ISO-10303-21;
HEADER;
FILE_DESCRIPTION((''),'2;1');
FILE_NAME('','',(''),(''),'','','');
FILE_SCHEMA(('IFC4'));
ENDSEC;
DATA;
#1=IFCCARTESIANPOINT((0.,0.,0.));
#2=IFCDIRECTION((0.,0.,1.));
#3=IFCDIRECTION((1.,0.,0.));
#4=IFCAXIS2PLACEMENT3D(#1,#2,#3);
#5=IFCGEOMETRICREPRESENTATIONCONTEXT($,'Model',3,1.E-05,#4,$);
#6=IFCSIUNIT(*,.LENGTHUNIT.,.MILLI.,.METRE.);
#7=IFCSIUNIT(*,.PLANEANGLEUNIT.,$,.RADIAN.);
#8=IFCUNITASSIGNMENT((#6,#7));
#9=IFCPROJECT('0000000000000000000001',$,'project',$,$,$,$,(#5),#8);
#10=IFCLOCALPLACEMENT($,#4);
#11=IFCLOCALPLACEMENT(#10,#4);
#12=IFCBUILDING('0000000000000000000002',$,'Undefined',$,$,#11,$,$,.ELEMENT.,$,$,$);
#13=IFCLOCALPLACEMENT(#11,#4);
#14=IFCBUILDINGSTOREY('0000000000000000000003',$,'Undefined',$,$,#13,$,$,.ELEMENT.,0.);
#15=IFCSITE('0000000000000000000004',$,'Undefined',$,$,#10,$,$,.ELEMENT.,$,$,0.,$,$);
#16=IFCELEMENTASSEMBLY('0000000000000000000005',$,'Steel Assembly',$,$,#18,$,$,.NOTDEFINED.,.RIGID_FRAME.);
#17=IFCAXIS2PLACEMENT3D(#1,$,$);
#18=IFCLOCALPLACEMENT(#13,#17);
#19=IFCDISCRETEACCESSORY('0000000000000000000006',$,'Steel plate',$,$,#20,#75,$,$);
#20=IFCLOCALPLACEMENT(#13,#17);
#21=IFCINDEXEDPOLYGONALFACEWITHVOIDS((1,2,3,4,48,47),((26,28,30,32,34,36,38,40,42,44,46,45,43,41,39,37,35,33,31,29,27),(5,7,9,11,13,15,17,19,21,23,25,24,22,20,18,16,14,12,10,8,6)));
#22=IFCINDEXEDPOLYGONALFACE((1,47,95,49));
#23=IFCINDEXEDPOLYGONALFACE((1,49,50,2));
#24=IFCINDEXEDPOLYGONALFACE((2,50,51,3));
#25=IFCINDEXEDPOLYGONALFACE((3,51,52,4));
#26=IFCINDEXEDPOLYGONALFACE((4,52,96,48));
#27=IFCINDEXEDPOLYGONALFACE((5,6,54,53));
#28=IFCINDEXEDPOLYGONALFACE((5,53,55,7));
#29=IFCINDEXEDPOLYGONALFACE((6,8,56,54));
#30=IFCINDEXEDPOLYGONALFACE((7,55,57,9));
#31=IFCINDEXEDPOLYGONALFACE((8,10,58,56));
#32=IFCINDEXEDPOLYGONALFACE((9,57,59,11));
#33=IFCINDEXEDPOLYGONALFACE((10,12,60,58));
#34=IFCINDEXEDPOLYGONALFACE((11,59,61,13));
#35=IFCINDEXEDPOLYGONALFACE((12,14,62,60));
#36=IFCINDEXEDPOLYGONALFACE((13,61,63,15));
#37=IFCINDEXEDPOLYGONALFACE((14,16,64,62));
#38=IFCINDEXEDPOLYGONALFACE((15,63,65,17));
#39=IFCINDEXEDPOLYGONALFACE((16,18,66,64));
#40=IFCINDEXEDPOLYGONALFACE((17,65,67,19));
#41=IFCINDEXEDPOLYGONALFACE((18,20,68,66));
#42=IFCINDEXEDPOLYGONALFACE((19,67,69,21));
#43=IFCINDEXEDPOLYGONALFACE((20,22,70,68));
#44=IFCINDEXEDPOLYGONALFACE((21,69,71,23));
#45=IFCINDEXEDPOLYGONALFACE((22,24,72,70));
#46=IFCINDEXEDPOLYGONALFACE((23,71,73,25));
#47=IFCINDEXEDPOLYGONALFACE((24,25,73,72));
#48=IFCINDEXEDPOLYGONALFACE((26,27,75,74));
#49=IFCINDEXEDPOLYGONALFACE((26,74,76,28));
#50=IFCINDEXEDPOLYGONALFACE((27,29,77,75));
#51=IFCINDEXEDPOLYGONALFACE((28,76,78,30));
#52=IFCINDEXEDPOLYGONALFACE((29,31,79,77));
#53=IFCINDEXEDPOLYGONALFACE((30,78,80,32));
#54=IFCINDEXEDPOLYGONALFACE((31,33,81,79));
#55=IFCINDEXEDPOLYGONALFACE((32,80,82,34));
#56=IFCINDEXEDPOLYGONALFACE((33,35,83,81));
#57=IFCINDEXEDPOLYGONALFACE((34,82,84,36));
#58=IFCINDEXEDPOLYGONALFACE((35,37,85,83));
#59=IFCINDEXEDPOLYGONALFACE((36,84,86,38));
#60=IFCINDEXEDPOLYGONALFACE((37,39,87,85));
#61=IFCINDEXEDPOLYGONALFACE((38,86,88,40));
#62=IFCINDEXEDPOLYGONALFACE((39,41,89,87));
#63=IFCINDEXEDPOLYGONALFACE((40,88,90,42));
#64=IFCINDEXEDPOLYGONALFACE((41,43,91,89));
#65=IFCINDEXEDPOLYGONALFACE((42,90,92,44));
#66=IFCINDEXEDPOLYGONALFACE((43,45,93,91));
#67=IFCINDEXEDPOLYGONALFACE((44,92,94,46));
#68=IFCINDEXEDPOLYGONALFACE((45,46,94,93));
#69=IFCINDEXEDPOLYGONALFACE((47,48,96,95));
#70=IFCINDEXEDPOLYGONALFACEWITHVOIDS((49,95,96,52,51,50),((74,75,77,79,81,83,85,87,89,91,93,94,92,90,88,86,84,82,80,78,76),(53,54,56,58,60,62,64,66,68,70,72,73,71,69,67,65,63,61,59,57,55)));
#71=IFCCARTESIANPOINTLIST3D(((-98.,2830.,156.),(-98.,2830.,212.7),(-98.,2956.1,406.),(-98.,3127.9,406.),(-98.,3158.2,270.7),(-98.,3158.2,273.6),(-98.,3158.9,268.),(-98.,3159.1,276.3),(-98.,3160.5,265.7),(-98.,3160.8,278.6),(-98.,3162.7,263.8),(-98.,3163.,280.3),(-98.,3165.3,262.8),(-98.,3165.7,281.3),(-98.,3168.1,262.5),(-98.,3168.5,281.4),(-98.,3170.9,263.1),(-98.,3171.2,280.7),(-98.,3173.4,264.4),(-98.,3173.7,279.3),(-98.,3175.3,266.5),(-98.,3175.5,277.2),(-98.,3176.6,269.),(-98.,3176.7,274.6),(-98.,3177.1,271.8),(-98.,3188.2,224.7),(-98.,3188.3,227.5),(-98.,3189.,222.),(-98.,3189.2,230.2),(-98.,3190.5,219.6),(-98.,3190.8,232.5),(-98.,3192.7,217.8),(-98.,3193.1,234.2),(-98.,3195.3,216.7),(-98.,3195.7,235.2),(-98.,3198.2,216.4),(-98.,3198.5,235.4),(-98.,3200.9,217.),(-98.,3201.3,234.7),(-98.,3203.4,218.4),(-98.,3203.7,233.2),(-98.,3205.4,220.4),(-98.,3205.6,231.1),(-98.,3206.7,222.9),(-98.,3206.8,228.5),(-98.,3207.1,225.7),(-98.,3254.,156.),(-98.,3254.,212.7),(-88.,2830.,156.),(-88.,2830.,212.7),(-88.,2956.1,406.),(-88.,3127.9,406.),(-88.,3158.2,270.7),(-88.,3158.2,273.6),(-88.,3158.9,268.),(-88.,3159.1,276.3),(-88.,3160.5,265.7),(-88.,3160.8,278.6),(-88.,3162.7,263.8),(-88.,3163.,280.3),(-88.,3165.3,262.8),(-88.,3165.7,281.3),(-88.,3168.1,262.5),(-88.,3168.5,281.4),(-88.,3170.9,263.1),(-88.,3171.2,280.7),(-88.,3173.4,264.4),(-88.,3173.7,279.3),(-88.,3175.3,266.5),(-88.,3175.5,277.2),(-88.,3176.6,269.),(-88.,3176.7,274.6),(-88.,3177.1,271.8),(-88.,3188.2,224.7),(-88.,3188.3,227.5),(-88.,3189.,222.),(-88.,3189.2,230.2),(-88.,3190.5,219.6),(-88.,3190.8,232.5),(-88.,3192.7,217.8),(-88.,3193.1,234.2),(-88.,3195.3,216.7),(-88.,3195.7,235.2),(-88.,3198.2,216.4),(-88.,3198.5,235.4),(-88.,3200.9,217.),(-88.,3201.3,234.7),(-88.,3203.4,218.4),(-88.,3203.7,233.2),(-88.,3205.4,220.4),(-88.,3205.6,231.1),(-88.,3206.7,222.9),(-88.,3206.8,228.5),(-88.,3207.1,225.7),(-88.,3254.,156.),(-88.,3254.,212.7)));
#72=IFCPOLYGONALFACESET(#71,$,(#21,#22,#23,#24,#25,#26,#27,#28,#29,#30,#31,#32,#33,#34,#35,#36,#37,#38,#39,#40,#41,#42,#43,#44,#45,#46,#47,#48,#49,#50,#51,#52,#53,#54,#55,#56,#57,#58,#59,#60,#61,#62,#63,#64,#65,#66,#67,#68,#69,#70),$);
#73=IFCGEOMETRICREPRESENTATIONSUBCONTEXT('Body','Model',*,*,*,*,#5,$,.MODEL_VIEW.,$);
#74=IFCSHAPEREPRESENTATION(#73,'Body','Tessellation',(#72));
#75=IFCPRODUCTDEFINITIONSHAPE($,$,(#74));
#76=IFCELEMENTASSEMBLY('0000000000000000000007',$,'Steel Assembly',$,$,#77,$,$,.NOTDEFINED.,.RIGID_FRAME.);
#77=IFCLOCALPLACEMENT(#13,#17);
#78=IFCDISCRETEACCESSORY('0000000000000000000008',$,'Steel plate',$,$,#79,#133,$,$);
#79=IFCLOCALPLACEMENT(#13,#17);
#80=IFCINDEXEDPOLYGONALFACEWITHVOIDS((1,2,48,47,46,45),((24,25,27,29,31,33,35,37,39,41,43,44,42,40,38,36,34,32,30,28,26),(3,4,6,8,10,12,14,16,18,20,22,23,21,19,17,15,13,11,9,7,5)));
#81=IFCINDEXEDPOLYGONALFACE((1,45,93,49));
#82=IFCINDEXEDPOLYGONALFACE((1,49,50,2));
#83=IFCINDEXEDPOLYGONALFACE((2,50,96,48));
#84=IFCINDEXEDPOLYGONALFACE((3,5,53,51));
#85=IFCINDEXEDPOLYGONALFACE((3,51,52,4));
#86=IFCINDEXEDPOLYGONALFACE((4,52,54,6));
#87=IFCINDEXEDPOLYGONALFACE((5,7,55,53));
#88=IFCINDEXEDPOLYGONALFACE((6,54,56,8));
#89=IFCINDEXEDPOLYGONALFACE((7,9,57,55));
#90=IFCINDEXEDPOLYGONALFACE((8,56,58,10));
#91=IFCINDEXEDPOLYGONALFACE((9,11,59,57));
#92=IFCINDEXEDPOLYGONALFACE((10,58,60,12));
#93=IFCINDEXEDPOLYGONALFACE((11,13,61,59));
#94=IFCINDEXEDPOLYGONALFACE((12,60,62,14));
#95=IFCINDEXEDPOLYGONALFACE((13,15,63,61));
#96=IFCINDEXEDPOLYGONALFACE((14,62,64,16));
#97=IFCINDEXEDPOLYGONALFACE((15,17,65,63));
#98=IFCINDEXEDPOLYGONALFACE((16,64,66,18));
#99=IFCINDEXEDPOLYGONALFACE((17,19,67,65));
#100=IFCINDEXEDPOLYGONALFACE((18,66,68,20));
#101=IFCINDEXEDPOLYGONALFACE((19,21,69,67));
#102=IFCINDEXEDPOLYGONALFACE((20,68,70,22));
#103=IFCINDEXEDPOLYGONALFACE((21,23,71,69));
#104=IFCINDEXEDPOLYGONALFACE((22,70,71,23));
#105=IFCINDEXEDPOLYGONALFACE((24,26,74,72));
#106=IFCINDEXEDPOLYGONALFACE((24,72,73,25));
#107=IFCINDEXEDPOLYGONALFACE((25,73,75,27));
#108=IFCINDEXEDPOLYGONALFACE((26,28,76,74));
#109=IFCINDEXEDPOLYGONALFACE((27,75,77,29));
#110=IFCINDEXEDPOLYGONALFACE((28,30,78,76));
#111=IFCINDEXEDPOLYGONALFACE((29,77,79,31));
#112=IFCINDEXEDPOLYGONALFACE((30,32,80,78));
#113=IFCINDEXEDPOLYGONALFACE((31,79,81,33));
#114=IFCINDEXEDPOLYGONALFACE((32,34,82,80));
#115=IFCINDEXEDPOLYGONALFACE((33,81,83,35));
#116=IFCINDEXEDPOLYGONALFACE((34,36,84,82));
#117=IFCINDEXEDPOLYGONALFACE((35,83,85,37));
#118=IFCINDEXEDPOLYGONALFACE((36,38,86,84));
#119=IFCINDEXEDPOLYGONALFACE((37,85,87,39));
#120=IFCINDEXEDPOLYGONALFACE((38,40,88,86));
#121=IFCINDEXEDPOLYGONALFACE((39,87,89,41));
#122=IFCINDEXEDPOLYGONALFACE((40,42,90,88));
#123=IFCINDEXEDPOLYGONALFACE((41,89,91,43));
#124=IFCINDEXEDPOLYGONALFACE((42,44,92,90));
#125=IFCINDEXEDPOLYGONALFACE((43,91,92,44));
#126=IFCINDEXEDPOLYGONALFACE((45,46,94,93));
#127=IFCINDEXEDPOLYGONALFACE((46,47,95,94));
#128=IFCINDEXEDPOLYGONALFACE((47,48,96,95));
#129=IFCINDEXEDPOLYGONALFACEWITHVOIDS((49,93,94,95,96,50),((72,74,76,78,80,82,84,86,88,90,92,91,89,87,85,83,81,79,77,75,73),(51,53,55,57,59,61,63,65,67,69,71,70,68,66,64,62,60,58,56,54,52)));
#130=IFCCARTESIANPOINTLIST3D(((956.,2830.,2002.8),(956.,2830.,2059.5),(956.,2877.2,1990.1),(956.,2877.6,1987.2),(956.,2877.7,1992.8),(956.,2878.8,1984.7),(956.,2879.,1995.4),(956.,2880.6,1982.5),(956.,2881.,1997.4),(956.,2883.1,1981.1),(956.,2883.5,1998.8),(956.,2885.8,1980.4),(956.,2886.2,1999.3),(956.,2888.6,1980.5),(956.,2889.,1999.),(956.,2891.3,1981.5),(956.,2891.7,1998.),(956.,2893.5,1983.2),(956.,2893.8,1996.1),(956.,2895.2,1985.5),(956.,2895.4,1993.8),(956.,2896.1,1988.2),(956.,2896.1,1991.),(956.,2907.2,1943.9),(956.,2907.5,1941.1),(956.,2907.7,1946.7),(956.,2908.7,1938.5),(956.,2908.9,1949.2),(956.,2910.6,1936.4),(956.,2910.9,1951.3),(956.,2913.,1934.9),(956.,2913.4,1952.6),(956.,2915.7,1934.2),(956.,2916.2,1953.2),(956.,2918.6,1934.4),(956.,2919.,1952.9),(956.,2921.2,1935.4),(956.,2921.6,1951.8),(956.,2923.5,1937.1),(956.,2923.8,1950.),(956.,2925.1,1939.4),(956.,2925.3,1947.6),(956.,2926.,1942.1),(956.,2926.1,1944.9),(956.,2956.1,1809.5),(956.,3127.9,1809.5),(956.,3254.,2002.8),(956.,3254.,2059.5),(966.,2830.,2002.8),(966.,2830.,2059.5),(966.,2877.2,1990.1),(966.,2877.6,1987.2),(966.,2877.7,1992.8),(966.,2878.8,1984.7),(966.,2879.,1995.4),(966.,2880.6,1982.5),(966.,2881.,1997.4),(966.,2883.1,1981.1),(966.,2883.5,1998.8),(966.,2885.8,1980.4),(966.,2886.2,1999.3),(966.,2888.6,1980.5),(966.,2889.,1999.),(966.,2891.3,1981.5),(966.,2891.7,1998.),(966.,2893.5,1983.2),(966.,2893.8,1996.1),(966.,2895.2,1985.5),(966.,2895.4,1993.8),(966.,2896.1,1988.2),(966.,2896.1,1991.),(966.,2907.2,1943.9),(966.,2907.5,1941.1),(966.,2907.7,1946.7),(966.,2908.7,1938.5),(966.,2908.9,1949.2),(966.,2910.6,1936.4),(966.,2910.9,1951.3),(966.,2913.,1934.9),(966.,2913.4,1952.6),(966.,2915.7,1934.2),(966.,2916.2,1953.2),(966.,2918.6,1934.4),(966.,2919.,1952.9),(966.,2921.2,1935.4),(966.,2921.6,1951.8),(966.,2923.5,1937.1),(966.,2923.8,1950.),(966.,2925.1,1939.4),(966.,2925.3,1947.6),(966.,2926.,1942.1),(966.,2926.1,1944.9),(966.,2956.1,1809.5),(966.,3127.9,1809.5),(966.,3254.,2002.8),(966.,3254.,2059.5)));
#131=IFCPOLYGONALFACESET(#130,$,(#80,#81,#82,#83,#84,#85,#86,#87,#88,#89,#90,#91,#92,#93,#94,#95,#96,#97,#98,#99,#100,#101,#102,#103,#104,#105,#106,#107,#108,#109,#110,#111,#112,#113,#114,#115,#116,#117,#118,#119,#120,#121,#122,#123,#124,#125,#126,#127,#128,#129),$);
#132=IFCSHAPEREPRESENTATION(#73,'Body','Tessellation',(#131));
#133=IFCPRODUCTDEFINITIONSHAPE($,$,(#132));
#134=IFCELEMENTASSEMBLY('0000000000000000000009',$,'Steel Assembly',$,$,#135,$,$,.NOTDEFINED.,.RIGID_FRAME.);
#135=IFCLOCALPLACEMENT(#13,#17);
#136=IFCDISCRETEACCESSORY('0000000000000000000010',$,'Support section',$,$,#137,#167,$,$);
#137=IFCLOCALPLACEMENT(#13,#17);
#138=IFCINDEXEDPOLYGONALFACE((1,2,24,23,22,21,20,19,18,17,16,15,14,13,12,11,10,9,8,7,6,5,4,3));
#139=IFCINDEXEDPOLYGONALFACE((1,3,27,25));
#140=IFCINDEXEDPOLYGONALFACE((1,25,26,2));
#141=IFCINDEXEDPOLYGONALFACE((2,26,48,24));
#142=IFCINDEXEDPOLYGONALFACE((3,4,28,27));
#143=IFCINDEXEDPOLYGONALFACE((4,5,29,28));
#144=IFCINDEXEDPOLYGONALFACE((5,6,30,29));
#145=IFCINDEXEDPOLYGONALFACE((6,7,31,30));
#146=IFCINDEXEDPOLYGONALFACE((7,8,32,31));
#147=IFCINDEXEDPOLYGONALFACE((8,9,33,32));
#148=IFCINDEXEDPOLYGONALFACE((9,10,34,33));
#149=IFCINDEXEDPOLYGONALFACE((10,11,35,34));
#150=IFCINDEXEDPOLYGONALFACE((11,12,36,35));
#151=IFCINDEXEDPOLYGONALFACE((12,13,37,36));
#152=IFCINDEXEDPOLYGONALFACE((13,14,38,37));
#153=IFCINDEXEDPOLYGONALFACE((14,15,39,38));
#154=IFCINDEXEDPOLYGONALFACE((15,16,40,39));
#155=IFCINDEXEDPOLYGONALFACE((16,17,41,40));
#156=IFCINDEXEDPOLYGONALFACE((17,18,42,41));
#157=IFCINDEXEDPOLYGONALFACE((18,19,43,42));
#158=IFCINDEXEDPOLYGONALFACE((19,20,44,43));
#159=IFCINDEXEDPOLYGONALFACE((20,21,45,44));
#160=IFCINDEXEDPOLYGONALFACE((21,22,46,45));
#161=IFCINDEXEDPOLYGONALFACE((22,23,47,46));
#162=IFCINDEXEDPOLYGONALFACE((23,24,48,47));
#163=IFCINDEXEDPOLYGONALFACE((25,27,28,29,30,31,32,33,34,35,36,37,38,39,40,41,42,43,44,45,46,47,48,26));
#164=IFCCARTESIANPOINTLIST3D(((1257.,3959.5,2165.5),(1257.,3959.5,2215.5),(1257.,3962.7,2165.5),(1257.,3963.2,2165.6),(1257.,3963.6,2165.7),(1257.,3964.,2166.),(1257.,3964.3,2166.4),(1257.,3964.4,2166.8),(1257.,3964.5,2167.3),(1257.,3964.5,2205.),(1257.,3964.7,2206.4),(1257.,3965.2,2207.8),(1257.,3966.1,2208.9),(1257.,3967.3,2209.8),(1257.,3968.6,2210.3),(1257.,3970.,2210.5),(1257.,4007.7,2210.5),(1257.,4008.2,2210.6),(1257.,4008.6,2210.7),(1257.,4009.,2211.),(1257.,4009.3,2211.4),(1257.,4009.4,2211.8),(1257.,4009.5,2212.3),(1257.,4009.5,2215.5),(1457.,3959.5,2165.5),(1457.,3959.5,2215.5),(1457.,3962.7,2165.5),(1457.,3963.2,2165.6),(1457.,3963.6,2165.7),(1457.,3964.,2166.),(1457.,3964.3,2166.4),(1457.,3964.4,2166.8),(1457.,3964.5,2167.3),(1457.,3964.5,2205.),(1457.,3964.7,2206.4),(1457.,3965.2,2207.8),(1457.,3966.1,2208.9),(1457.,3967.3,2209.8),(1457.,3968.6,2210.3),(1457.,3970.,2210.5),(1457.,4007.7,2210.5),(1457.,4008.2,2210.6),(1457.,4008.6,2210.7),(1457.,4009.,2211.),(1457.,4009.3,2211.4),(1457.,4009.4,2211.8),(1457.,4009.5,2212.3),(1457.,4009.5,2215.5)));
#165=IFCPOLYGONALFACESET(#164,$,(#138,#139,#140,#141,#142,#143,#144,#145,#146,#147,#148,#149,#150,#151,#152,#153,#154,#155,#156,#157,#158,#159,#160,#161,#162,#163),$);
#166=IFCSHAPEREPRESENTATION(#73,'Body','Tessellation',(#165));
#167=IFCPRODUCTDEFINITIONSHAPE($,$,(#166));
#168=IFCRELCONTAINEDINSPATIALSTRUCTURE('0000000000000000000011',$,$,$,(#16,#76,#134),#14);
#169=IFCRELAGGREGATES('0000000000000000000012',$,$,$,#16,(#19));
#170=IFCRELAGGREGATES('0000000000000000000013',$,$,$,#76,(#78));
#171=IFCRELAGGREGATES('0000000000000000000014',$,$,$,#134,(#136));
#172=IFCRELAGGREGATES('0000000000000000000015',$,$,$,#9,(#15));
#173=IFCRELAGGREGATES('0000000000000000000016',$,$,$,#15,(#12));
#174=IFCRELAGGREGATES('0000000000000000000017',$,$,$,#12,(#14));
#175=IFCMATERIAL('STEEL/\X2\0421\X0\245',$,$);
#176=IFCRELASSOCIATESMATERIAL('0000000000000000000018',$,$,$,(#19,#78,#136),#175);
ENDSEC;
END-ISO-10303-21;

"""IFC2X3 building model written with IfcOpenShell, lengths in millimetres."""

from ifc_helpers import new_model, si_unit, frame, origin_with_axes, origin_2d_with_axis, place, context, subcontext, project, spatial, polyline, circle, l_section, outline, extrude, source, transform, mapped, material, element, aggregate, save


model = new_model("IFC2X3")

# Units and contexts
model_context = context("Model", 3, precision=1e-05, world=origin_with_axes())
body_context = subcontext(model_context, "Body", "Model", "MODEL_VIEW")
ifc_project = project(units=[si_unit("LENGTHUNIT", "METRE", prefix="MILLI"), si_unit("PLANEANGLEUNIT", "RADIAN")], contexts=[model_context])

# Site, building, storey
site_placement = place(None, origin_with_axes())
site = spatial("IfcSite", under=ifc_project, at=site_placement, Name="Undefined", CompositionType="ELEMENT", RefElevation=0.0)
building_placement = place(site_placement, origin_with_axes())
building = spatial("IfcBuilding", under=site, at=building_placement, Name="Undefined", CompositionType="ELEMENT")
storey_placement = place(building_placement, origin_with_axes())
storey = spatial("IfcBuildingStorey", under=building, at=storey_placement, Name="Undefined", CompositionType="ELEMENT", Elevation=0.0)

# Shared definitions
ifc_material_1 = material(Name="STEEL/С245")

# Element assemblies, discrete accessories, openings
assembly_1_placement = place(storey_placement, origin_with_axes())
assembly_1 = element("IfcElementAssembly", 1, at=assembly_1_placement, inside=storey, Name="Steel Assembly", AssemblyPlace="NOTDEFINED", PredefinedType="RIGID_FRAME")
discrete_accessory_1_placement = place(assembly_1_placement, frame((-93.0, 3254.0, 156.0), z_axis=(-1.0, 0.0, 0.0), x_axis=(0.0, -1.0, 0.0)))
discrete_accessory_1 = element("IfcDiscreteAccessory", 2, at=discrete_accessory_1_placement, material=ifc_material_1, Name="Steel plate", context=body_context, shape_type="SweptSolid", body=[
    extrude(outline(polyline([(0.0, 0.0), (424.0, 0.0), (424.0, 56.7), (297.9, 250.0), (126.1, 250.0), (0.0, 56.7), (0.0, 0.0)])), frame((0.0, 0.0, -5.0), z_axis=(0.0, 0.0, 1.0), x_axis=(1.0, 0.0, 0.0)), (0.0, 0.0, 1.0), 10.0),
])
shared_shape_1 = source(origin_with_axes(), body_context, "Body", "SweptSolid", [
    extrude(circle(Radius=9.5, at=origin_2d_with_axis()), frame((0.0, 3.9, 0.0), z_axis=(0.0, 1.0, 0.0), x_axis=(1.0, 0.0, 0.0)), (0.0, 0.0, 1.0), 14.1),
])
opening_1_placement = place(assembly_1_placement, frame((-84.0, 3182.6, 248.9), z_axis=(0.0, -0.546313, 0.837581), x_axis=(0.0, 0.837581, 0.546313)))
element("IfcOpeningElement", 3, at=opening_1_placement, cuts=discrete_accessory_1, ObjectType="Opening", context=body_context, shape_type="MappedRepresentation", body=[
    mapped(shared_shape_1, transform((0.0, 0.0, -27.5))),
    mapped(shared_shape_1, transform((0.0, 0.0, 27.5))),
])
aggregate(assembly_1, [discrete_accessory_1])
assembly_2_placement = place(storey_placement, origin_with_axes())
assembly_2 = element("IfcElementAssembly", 4, at=assembly_2_placement, inside=storey, Name="Steel Assembly", AssemblyPlace="NOTDEFINED", PredefinedType="RIGID_FRAME")
discrete_accessory_2_placement = place(assembly_2_placement, frame((961.0, 3254.0, 2059.5), z_axis=(1.0, 0.0, 0.0), x_axis=(0.0, -1.0, 0.0)))
discrete_accessory_2 = element("IfcDiscreteAccessory", 5, at=discrete_accessory_2_placement, material=ifc_material_1, Name="Steel plate", context=body_context, shape_type="SweptSolid", body=[
    extrude(outline(polyline([(0.0, 0.0), (424.0, 0.0), (424.0, 56.7), (297.9, 250.0), (126.1, 250.0), (0.0, 56.7), (0.0, 0.0)])), frame((0.0, 0.0, -5.0), z_axis=(0.0, 0.0, 1.0), x_axis=(1.0, 0.0, 0.0)), (0.0, 0.0, 1.0), 10.0),
])
shared_shape_2 = source(origin_with_axes(), body_context, "Body", "SweptSolid", [
    extrude(circle(Radius=9.5, at=origin_2d_with_axis()), frame((0.0, -14.1, 0.0), z_axis=(0.0, 1.0, 0.0), x_axis=(1.0, 0.0, 0.0)), (0.0, 0.0, 1.0), 24.3),
])
opening_2_placement = place(assembly_2_placement, frame((970.0, 2901.7, 1966.8), z_axis=(0.0, -0.544395, 0.838829), x_axis=(0.0, -0.838829, -0.544395)))
element("IfcOpeningElement", 6, at=opening_2_placement, cuts=discrete_accessory_2, ObjectType="Opening", context=body_context, shape_type="MappedRepresentation", body=[
    mapped(shared_shape_2, transform((0.0, 0.0, -27.5))),
    mapped(shared_shape_2, transform((0.0, 0.0, 27.5))),
])
aggregate(assembly_2, [discrete_accessory_2])

# Element assembly, discrete accessory
assembly_3_placement = place(storey_placement, origin_with_axes())
assembly_3 = element("IfcElementAssembly", 7, at=assembly_3_placement, inside=storey, Name="Steel Assembly", AssemblyPlace="NOTDEFINED", PredefinedType="RIGID_FRAME")
discrete_accessory_3_placement = place(assembly_3_placement, frame((1457.0, 3984.5, 2190.5), z_axis=(0.0, 1.0, 0.0), x_axis=(-1.0, 0.0, 0.0)))
discrete_accessory_3 = element("IfcDiscreteAccessory", 8, at=discrete_accessory_3_placement, material=ifc_material_1, Name="Support section", context=body_context, shape_type="SweptSolid", body=[
    extrude(l_section(Depth=50.0, Width=50.0, Thickness=5.0, FilletRadius=5.5, EdgeRadius=1.8, at=origin_2d_with_axis()), frame((200.0, 0.0, 0.0), z_axis=(-1.0, 0.0, 0.0), x_axis=(0.0, -1.0, 0.0)), (0.0, 0.0, 1.0), 200.0),
])
aggregate(assembly_3, [discrete_accessory_3])

save(model, "model.ifc")
